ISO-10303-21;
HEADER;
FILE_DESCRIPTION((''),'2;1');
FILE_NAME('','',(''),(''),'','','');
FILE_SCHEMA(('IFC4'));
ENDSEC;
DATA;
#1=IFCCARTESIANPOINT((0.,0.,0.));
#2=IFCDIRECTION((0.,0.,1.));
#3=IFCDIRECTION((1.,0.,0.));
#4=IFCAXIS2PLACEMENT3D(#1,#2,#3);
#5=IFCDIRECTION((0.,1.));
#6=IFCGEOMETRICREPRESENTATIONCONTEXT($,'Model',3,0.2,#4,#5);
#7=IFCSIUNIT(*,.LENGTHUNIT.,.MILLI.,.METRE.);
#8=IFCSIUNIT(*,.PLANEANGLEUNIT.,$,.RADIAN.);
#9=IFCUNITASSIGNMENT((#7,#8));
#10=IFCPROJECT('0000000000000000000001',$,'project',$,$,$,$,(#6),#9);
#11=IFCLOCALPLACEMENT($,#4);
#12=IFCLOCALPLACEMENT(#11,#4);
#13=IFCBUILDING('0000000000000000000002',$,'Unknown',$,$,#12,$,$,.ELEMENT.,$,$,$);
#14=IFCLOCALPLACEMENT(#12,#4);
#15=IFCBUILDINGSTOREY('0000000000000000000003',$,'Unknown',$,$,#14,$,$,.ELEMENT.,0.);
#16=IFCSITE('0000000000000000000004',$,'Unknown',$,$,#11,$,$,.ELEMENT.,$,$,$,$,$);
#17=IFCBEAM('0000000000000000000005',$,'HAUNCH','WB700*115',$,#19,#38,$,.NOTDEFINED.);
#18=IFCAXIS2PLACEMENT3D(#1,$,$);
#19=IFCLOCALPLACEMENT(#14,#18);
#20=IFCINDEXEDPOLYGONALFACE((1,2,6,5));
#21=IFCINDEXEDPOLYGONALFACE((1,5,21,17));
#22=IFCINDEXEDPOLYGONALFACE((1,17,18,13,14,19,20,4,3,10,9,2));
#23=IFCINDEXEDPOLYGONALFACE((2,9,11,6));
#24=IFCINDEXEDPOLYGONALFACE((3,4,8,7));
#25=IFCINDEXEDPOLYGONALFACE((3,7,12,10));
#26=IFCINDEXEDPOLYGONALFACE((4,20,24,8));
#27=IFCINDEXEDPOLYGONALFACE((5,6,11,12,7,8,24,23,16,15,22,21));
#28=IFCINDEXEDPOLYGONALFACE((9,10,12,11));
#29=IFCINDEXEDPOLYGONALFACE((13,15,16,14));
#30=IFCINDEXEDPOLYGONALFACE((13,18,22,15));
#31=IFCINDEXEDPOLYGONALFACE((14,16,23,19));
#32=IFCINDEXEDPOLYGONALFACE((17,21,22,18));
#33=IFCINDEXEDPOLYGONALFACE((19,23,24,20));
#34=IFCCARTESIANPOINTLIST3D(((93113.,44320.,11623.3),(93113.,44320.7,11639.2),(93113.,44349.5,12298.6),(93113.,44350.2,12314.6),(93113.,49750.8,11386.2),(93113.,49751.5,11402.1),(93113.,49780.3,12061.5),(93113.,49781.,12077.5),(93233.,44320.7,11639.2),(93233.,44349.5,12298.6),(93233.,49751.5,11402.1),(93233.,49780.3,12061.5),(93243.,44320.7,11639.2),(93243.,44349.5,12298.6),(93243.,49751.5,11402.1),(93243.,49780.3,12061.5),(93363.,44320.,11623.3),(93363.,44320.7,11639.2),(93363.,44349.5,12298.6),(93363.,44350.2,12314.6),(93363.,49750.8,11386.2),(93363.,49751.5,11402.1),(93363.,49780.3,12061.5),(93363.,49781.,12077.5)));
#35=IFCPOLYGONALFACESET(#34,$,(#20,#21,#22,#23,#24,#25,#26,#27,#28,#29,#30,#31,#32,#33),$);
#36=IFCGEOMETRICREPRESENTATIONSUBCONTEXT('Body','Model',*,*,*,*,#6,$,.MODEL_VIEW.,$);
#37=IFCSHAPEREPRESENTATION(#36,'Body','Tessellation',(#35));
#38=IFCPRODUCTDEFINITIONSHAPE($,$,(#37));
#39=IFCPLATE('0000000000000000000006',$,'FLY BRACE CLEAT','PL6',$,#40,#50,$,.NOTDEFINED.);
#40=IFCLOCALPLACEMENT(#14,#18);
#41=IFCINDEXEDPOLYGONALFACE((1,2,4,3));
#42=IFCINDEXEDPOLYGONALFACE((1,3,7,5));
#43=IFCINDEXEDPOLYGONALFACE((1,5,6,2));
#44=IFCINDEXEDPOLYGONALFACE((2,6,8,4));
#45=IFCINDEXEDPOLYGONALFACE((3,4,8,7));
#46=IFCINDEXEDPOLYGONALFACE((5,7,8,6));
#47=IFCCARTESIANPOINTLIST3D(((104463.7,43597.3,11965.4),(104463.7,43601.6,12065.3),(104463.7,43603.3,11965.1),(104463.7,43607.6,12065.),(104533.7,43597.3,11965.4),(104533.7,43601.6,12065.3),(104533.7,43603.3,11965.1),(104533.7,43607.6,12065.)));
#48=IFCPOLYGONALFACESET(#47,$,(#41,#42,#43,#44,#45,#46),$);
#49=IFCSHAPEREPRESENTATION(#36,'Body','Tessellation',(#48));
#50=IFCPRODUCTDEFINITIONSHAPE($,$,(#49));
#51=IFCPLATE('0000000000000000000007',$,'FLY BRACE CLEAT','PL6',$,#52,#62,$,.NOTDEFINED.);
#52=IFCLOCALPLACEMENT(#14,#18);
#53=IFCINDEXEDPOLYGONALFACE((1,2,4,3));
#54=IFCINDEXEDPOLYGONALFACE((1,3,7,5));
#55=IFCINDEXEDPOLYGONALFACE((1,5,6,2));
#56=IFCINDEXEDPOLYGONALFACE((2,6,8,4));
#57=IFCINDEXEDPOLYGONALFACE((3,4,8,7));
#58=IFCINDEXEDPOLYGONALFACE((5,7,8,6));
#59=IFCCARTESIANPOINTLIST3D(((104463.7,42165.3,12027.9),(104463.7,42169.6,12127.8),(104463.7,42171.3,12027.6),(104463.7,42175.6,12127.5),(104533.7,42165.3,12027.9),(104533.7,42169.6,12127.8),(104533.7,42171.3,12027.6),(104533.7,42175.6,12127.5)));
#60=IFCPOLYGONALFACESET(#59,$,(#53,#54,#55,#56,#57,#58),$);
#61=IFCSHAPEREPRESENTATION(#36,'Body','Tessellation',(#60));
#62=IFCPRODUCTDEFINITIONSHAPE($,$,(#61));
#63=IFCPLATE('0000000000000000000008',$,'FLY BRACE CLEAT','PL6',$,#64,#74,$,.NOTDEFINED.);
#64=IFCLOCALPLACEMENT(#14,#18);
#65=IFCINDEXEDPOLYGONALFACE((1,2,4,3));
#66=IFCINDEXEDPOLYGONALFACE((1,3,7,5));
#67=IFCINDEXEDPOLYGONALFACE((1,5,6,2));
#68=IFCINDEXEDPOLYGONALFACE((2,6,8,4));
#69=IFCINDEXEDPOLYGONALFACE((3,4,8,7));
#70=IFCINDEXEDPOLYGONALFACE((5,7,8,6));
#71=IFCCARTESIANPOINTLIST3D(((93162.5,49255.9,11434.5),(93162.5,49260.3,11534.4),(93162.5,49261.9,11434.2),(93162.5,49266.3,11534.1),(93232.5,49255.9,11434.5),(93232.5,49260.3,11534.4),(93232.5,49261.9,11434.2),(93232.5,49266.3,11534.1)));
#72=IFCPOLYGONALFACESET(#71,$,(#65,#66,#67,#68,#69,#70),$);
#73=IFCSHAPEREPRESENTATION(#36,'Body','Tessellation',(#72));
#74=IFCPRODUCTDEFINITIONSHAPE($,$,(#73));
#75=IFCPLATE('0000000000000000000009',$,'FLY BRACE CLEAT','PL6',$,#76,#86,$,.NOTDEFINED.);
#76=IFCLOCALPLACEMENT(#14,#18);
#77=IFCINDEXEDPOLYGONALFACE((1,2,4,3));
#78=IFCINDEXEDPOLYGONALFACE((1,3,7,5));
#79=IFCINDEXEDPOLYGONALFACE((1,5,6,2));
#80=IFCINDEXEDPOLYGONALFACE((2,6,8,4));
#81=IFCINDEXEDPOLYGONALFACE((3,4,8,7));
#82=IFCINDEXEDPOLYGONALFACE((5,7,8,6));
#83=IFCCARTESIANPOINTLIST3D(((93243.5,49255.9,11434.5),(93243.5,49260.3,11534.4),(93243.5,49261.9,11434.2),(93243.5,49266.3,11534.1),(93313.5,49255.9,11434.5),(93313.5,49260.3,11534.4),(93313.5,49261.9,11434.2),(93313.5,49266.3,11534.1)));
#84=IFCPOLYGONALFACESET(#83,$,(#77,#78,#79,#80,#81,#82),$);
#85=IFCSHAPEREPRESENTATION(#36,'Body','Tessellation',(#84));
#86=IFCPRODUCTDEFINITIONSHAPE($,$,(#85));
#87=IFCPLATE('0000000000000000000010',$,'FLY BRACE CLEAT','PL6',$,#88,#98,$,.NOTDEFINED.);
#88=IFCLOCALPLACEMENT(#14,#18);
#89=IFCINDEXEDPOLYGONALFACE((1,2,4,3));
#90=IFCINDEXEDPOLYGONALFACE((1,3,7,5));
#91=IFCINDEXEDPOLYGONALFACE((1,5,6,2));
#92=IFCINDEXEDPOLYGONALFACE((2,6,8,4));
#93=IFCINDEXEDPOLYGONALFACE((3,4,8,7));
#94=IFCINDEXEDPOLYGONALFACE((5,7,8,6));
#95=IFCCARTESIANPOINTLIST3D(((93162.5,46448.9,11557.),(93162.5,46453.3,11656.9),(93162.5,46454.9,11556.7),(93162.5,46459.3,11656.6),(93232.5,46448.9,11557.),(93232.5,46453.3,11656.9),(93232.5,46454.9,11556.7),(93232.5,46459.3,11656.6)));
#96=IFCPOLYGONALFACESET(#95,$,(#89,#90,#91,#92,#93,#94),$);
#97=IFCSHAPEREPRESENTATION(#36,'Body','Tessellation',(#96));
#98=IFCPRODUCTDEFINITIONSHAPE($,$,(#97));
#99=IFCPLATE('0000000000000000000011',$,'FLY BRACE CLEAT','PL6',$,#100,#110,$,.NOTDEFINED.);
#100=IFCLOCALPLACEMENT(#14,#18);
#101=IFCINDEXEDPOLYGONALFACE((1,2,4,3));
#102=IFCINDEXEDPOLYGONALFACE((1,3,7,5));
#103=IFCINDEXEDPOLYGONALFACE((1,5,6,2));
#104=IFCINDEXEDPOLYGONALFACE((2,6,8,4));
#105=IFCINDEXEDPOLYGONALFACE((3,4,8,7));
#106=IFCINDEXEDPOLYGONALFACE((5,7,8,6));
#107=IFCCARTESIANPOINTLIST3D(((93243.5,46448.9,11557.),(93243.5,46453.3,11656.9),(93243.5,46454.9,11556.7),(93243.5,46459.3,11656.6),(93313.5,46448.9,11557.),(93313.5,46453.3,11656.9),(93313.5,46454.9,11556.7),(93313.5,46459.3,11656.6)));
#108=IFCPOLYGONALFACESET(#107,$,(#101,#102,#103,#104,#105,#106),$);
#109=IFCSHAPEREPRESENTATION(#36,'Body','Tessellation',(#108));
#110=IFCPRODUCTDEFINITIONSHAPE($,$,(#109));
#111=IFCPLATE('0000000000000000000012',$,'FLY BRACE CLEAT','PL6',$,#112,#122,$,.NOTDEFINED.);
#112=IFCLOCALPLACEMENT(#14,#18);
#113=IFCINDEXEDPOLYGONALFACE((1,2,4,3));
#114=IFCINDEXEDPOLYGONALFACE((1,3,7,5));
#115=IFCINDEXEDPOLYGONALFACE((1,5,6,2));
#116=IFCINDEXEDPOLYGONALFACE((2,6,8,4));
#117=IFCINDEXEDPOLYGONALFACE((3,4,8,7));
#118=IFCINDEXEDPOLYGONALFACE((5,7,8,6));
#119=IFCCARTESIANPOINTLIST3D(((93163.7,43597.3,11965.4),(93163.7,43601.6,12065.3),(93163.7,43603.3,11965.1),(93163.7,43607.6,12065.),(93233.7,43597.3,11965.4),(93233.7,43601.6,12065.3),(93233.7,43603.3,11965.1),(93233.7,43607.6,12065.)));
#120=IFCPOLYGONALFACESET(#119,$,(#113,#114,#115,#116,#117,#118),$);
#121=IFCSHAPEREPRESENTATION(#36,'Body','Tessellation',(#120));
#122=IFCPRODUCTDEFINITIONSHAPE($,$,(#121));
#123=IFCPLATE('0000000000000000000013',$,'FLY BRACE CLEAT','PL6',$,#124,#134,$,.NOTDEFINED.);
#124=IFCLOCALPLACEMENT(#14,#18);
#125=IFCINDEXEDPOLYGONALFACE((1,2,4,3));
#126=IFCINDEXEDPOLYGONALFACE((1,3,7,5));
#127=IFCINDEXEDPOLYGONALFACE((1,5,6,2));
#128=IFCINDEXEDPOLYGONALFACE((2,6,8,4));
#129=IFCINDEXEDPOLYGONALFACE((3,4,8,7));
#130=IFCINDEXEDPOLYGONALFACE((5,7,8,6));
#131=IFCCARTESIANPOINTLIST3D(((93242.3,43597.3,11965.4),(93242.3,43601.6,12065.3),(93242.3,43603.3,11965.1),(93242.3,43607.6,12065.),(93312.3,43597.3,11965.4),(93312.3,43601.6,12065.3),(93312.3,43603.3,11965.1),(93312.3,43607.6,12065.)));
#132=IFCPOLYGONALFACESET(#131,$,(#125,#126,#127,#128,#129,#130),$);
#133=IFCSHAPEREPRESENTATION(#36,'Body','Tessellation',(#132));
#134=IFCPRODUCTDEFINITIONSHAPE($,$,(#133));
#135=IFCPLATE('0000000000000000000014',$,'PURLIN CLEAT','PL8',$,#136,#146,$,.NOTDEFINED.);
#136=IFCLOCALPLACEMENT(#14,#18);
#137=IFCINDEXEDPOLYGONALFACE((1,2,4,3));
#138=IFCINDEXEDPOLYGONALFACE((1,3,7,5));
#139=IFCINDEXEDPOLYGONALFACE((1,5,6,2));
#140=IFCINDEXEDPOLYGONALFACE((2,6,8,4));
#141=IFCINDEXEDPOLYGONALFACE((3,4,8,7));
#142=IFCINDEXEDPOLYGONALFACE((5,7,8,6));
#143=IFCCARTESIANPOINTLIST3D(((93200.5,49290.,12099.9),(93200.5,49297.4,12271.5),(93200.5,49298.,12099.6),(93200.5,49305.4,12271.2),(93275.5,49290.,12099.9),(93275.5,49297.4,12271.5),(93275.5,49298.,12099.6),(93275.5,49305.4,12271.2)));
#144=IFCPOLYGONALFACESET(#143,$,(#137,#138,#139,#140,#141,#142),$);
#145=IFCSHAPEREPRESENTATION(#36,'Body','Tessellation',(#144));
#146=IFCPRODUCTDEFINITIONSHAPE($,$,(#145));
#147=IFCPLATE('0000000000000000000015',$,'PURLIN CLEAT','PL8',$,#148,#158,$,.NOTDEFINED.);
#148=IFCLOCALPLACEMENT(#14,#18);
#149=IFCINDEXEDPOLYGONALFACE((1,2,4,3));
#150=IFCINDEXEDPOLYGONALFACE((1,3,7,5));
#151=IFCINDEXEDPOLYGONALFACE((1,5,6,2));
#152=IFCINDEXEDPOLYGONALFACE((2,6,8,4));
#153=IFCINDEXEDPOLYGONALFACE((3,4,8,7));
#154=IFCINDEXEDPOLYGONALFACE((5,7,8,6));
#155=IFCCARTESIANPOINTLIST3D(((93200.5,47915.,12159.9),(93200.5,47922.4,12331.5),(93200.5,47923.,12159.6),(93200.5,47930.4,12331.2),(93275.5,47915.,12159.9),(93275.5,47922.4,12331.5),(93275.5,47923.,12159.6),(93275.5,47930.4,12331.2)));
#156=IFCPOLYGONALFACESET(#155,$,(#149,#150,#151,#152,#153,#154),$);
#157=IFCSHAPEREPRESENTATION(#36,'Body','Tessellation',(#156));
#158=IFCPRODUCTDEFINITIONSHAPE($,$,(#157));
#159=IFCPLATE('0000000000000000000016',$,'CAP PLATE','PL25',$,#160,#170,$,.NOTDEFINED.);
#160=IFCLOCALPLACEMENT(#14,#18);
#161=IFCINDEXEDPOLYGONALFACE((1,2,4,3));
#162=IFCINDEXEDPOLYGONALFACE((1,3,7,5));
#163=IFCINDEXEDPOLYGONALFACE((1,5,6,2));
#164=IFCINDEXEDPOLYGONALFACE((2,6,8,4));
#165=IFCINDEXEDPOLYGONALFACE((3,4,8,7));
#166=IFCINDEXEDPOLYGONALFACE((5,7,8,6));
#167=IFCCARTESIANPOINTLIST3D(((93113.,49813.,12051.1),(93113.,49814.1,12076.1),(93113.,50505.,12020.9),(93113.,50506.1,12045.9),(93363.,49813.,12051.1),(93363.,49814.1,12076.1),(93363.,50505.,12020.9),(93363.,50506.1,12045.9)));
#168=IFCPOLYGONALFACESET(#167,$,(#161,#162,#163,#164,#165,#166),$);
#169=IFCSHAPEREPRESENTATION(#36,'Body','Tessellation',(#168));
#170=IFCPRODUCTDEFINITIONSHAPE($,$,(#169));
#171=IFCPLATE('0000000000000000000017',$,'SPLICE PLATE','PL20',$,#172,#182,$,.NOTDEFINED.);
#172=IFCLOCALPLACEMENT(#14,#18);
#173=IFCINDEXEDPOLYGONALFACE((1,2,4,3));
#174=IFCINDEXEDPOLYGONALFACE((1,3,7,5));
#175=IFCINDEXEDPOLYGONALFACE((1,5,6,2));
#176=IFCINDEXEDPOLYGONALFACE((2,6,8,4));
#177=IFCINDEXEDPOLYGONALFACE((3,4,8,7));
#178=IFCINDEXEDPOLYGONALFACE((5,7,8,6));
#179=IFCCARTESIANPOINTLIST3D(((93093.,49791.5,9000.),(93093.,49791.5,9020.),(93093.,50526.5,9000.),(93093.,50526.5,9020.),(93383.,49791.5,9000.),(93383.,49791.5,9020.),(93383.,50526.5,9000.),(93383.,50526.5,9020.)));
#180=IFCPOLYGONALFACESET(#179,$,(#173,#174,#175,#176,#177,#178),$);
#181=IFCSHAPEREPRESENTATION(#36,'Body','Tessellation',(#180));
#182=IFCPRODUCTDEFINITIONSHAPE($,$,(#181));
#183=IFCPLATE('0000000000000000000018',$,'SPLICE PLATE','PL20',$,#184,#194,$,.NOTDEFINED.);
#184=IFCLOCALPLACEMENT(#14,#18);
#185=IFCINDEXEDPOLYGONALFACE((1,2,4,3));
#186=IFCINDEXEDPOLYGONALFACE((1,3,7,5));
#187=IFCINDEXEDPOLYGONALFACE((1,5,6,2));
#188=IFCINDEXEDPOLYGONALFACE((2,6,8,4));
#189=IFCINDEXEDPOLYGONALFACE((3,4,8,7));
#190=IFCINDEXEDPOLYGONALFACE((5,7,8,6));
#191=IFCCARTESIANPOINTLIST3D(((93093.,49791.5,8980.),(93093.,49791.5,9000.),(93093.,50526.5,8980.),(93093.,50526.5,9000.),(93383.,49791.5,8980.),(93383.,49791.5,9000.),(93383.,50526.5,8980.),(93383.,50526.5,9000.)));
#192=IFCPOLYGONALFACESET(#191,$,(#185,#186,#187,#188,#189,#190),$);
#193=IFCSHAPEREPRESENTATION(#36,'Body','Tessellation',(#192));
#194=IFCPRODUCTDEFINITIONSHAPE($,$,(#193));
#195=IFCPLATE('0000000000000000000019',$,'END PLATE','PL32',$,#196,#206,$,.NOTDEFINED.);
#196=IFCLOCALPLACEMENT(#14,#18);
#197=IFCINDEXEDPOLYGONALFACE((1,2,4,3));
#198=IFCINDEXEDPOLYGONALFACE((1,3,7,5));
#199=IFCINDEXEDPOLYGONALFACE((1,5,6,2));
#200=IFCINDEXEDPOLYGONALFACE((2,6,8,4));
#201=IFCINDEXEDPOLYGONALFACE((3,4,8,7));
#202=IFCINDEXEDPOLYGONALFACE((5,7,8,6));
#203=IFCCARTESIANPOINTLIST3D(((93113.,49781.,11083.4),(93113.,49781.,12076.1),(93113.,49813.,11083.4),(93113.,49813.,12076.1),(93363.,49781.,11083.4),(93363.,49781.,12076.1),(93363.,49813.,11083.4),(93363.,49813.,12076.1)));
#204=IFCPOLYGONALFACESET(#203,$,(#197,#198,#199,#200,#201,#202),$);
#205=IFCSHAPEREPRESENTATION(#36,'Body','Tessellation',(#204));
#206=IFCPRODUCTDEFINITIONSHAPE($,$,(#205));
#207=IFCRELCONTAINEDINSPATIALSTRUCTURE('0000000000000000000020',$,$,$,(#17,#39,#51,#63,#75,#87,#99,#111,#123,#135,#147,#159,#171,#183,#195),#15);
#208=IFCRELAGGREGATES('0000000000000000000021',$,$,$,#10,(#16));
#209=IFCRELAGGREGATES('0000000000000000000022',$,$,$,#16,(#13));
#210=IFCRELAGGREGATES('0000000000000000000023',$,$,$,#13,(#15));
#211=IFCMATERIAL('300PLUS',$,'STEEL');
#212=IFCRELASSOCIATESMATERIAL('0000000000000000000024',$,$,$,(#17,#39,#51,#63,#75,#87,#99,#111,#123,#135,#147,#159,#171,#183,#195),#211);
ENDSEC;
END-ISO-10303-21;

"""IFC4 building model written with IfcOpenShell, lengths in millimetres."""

from ifc_helpers import new_model, si_unit, direction, frame, origin_with_axes, place, context, subcontext, project, spatial, line, indexed_curve, outline, extrude, material, element, save


model = new_model("IFC4")

# Units and contexts
model_context = context("Model", 3, precision=0.2, world=origin_with_axes(), true_north=direction((0.0, 1.0)))
body_context = subcontext(model_context, "Body", "Model", "MODEL_VIEW")
ifc_project = project(units=[si_unit("LENGTHUNIT", "METRE", prefix="MILLI"), si_unit("PLANEANGLEUNIT", "RADIAN")], contexts=[model_context])

# Site, building, storey
site_placement = place(None, origin_with_axes())
site = spatial("IfcSite", under=ifc_project, at=site_placement, Name="Unknown", CompositionType="ELEMENT")
building_placement = place(site_placement, origin_with_axes())
building = spatial("IfcBuilding", under=site, at=building_placement, Name="Unknown", CompositionType="ELEMENT")
storey_placement = place(building_placement, origin_with_axes())
storey = spatial("IfcBuildingStorey", under=building, at=storey_placement, Name="Unknown", CompositionType="ELEMENT", Elevation=0.0)

# Shared definitions
ifc_material_1 = material(Name="300PLUS", Category="STEEL")

# Beam
beam_1_placement = place(storey_placement, frame((93238.0, 49765.9, 11731.8), z_axis=(-1.0, 0.0, 0.0), x_axis=(0.0, -0.999048, 0.043617)))
element("IfcBeam", 1, at=beam_1_placement, inside=storey, material=ifc_material_1, Name="HAUNCH", Description="WB700*115", PredefinedType="NOTDEFINED", context=body_context, shape_type="SolidModel", body=[
    extrude(outline(indexed_curve([(-125.0, -346.0), (125.0, -346.0), (125.0, -330.0), (5.0, -330.0), (5.0, 330.0), (125.0, 330.0), (125.0, 346.0), (-125.0, 346.0), (-125.0, 330.0), (-5.0, 330.0), (-5.0, -330.0), (-125.0, -330.0)], segments=[line(1, 2, 3, 4, 5, 6, 7, 8, 9, 10, 11, 12, 1)])), frame((0.0, 0.0, 0.0), z_axis=(-1.0, 0.0, 0.0), x_axis=(0.0, 0.0, 1.0)), (0.0, 0.0, -1.0), 5436.0),
])

# Plates
for number, where, z_axis, x_axis, name in (
    (2, (104463.7, 43600.3, 11965.2), (0.0, -0.999075, 0.043003), (1.0, 0.0, 0.0), "FLY BRACE CLEAT"),
    (3, (104463.7, 42168.3, 12027.7), (0.0, -0.999075, 0.043003), (1.0, 0.0, 0.0), "FLY BRACE CLEAT"),
):
    element("IfcPlate", number, at=place(storey_placement, frame(where, z_axis=z_axis, x_axis=x_axis)), inside=storey, material=ifc_material_1, Name=name, Description="PL6", PredefinedType="NOTDEFINED", context=body_context, shape_type="SolidModel", body=[
        extrude(outline(indexed_curve([(0.0, 0.0), (70.0, 0.0), (70.0, 100.0), (0.0, 100.0)], segments=[line(1, 2, 3, 4, 1)])), frame((0.0, 0.0, 3.0), z_axis=(0.0, 0.0, 1.0), x_axis=(1.0, 0.0, 0.0)), (0.0, 0.0, -1.0), 6.0),
    ])
for number, where, z_axis, x_axis, name in (
    (4, (93232.5, 49263.3, 11534.2), (0.0, -0.999031, 0.044001), (-1.0, 0.0, 0.0), "FLY BRACE CLEAT"),
    (5, (93313.5, 49263.3, 11534.2), (0.0, -0.999031, 0.044001), (-1.0, 0.0, 0.0), "FLY BRACE CLEAT"),
    (6, (93232.5, 46456.3, 11656.7), (0.0, -0.999031, 0.044001), (-1.0, 0.0, 0.0), "FLY BRACE CLEAT"),
    (7, (93313.5, 46456.3, 11656.7), (0.0, -0.999031, 0.044001), (-1.0, 0.0, 0.0), "FLY BRACE CLEAT"),
):
    element("IfcPlate", number, at=place(storey_placement, frame(where, z_axis=z_axis, x_axis=x_axis)), inside=storey, material=ifc_material_1, Name=name, Description="PL6", PredefinedType="NOTDEFINED", context=body_context, shape_type="SolidModel", body=[
        extrude(outline(indexed_curve([(0.0, 0.0), (70.0, 0.0), (70.0, 100.0), (0.0, 100.0)], segments=[line(1, 2, 3, 4, 1)])), frame((0.0, 0.0, 3.0), z_axis=(0.0, 0.0, 1.0), x_axis=(1.0, 0.0, 0.0)), (0.0, 0.0, -1.0), 6.0),
    ])
for number, where, z_axis, x_axis, name in (
    (8, (93163.7, 43600.3, 11965.2), (0.0, -0.999075, 0.043003), (1.0, 0.0, 0.0), "FLY BRACE CLEAT"),
    (9, (93242.3, 43600.3, 11965.2), (0.0, -0.999075, 0.043003), (1.0, 0.0, 0.0), "FLY BRACE CLEAT"),
):
    element("IfcPlate", number, at=place(storey_placement, frame(where, z_axis=z_axis, x_axis=x_axis)), inside=storey, material=ifc_material_1, Name=name, Description="PL6", PredefinedType="NOTDEFINED", context=body_context, shape_type="SolidModel", body=[
        extrude(outline(indexed_curve([(0.0, 0.0), (70.0, 0.0), (70.0, 100.0), (0.0, 100.0)], segments=[line(1, 2, 3, 4, 1)])), frame((0.0, 0.0, 3.0), z_axis=(0.0, 0.0, 1.0), x_axis=(1.0, 0.0, 0.0)), (0.0, 0.0, -1.0), 6.0),
    ])
for number, where, z_axis, x_axis, name in (
    (10, (93200.5, 49294.0, 12099.8), (0.0, -0.999071, 0.043084), (1.0, 0.0, 0.0), "PURLIN CLEAT"),
    (11, (93200.5, 47919.0, 12159.8), (0.0, -0.999071, 0.043084), (1.0, 0.0, 0.0), "PURLIN CLEAT"),
):
    element("IfcPlate", number, at=place(storey_placement, frame(where, z_axis=z_axis, x_axis=x_axis)), inside=storey, material=ifc_material_1, Name=name, Description="PL8", PredefinedType="NOTDEFINED", context=body_context, shape_type="SolidModel", body=[
        extrude(outline(indexed_curve([(0.0, 0.0), (75.0, 0.0), (75.0, 171.8), (0.0, 171.8)], segments=[line(1, 2, 3, 4, 1)])), frame((0.0, 0.0, 4.0), z_axis=(0.0, 0.0, 1.0), x_axis=(1.0, 0.0, 0.0)), (0.0, 0.0, -1.0), 8.0),
    ])
plate_1_placement = place(storey_placement, frame((93363.0, 49813.5, 12063.6), z_axis=(0.0, 0.0436, 0.999049), x_axis=(0.0, 0.999049, -0.0436)))
element("IfcPlate", 12, at=plate_1_placement, inside=storey, material=ifc_material_1, Name="CAP PLATE", Description="PL25", PredefinedType="NOTDEFINED", context=body_context, shape_type="SolidModel", body=[
    extrude(outline(indexed_curve([(0.0, 0.0), (692.7, 0.0), (692.7, 250.0), (0.0, 250.0)], segments=[line(1, 2, 3, 4, 1)])), frame((0.0, 0.0, 12.5), z_axis=(0.0, 0.0, 1.0), x_axis=(1.0, 0.0, 0.0)), (0.0, 0.0, -1.0), 25.0),
])
for number, where, z_axis, x_axis, name in (
    (13, (93383.0, 49791.5, 9010.0), (0.0, 0.0, 1.0), (0.0, 1.0, 0.0), "SPLICE PLATE"),
    (14, (93383.0, 49791.5, 8990.0), (0.0, 0.0, 1.0), (0.0, 1.0, 0.0), "SPLICE PLATE"),
):
    element("IfcPlate", number, at=place(storey_placement, frame(where, z_axis=z_axis, x_axis=x_axis)), inside=storey, material=ifc_material_1, Name=name, Description="PL20", PredefinedType="NOTDEFINED", context=body_context, shape_type="SolidModel", body=[
        extrude(outline(indexed_curve([(0.0, 0.0), (735.0, 0.0), (735.0, 290.0), (0.0, 290.0)], segments=[line(1, 2, 3, 4, 1)])), frame((0.0, 0.0, 10.0), z_axis=(0.0, 0.0, 1.0), x_axis=(1.0, 0.0, 0.0)), (0.0, 0.0, -1.0), 20.0),
    ])
plate_2_placement = place(storey_placement, frame((93363.0, 49797.0, 12076.1), z_axis=(0.0, -1.0, 0.0), x_axis=(-1.0, 0.0, 0.0)))
element("IfcPlate", 15, at=plate_2_placement, inside=storey, material=ifc_material_1, Name="END PLATE", Description="PL32", PredefinedType="NOTDEFINED", context=body_context, shape_type="SolidModel", body=[
    extrude(outline(indexed_curve([(0.0, 0.0), (250.0, 0.0), (250.0, 992.7), (0.0, 992.7)], segments=[line(1, 2, 3, 4, 1)])), frame((0.0, 0.0, 16.0), z_axis=(0.0, 0.0, 1.0), x_axis=(1.0, 0.0, 0.0)), (0.0, 0.0, -1.0), 32.0),
])

save(model, "model.ifc")
